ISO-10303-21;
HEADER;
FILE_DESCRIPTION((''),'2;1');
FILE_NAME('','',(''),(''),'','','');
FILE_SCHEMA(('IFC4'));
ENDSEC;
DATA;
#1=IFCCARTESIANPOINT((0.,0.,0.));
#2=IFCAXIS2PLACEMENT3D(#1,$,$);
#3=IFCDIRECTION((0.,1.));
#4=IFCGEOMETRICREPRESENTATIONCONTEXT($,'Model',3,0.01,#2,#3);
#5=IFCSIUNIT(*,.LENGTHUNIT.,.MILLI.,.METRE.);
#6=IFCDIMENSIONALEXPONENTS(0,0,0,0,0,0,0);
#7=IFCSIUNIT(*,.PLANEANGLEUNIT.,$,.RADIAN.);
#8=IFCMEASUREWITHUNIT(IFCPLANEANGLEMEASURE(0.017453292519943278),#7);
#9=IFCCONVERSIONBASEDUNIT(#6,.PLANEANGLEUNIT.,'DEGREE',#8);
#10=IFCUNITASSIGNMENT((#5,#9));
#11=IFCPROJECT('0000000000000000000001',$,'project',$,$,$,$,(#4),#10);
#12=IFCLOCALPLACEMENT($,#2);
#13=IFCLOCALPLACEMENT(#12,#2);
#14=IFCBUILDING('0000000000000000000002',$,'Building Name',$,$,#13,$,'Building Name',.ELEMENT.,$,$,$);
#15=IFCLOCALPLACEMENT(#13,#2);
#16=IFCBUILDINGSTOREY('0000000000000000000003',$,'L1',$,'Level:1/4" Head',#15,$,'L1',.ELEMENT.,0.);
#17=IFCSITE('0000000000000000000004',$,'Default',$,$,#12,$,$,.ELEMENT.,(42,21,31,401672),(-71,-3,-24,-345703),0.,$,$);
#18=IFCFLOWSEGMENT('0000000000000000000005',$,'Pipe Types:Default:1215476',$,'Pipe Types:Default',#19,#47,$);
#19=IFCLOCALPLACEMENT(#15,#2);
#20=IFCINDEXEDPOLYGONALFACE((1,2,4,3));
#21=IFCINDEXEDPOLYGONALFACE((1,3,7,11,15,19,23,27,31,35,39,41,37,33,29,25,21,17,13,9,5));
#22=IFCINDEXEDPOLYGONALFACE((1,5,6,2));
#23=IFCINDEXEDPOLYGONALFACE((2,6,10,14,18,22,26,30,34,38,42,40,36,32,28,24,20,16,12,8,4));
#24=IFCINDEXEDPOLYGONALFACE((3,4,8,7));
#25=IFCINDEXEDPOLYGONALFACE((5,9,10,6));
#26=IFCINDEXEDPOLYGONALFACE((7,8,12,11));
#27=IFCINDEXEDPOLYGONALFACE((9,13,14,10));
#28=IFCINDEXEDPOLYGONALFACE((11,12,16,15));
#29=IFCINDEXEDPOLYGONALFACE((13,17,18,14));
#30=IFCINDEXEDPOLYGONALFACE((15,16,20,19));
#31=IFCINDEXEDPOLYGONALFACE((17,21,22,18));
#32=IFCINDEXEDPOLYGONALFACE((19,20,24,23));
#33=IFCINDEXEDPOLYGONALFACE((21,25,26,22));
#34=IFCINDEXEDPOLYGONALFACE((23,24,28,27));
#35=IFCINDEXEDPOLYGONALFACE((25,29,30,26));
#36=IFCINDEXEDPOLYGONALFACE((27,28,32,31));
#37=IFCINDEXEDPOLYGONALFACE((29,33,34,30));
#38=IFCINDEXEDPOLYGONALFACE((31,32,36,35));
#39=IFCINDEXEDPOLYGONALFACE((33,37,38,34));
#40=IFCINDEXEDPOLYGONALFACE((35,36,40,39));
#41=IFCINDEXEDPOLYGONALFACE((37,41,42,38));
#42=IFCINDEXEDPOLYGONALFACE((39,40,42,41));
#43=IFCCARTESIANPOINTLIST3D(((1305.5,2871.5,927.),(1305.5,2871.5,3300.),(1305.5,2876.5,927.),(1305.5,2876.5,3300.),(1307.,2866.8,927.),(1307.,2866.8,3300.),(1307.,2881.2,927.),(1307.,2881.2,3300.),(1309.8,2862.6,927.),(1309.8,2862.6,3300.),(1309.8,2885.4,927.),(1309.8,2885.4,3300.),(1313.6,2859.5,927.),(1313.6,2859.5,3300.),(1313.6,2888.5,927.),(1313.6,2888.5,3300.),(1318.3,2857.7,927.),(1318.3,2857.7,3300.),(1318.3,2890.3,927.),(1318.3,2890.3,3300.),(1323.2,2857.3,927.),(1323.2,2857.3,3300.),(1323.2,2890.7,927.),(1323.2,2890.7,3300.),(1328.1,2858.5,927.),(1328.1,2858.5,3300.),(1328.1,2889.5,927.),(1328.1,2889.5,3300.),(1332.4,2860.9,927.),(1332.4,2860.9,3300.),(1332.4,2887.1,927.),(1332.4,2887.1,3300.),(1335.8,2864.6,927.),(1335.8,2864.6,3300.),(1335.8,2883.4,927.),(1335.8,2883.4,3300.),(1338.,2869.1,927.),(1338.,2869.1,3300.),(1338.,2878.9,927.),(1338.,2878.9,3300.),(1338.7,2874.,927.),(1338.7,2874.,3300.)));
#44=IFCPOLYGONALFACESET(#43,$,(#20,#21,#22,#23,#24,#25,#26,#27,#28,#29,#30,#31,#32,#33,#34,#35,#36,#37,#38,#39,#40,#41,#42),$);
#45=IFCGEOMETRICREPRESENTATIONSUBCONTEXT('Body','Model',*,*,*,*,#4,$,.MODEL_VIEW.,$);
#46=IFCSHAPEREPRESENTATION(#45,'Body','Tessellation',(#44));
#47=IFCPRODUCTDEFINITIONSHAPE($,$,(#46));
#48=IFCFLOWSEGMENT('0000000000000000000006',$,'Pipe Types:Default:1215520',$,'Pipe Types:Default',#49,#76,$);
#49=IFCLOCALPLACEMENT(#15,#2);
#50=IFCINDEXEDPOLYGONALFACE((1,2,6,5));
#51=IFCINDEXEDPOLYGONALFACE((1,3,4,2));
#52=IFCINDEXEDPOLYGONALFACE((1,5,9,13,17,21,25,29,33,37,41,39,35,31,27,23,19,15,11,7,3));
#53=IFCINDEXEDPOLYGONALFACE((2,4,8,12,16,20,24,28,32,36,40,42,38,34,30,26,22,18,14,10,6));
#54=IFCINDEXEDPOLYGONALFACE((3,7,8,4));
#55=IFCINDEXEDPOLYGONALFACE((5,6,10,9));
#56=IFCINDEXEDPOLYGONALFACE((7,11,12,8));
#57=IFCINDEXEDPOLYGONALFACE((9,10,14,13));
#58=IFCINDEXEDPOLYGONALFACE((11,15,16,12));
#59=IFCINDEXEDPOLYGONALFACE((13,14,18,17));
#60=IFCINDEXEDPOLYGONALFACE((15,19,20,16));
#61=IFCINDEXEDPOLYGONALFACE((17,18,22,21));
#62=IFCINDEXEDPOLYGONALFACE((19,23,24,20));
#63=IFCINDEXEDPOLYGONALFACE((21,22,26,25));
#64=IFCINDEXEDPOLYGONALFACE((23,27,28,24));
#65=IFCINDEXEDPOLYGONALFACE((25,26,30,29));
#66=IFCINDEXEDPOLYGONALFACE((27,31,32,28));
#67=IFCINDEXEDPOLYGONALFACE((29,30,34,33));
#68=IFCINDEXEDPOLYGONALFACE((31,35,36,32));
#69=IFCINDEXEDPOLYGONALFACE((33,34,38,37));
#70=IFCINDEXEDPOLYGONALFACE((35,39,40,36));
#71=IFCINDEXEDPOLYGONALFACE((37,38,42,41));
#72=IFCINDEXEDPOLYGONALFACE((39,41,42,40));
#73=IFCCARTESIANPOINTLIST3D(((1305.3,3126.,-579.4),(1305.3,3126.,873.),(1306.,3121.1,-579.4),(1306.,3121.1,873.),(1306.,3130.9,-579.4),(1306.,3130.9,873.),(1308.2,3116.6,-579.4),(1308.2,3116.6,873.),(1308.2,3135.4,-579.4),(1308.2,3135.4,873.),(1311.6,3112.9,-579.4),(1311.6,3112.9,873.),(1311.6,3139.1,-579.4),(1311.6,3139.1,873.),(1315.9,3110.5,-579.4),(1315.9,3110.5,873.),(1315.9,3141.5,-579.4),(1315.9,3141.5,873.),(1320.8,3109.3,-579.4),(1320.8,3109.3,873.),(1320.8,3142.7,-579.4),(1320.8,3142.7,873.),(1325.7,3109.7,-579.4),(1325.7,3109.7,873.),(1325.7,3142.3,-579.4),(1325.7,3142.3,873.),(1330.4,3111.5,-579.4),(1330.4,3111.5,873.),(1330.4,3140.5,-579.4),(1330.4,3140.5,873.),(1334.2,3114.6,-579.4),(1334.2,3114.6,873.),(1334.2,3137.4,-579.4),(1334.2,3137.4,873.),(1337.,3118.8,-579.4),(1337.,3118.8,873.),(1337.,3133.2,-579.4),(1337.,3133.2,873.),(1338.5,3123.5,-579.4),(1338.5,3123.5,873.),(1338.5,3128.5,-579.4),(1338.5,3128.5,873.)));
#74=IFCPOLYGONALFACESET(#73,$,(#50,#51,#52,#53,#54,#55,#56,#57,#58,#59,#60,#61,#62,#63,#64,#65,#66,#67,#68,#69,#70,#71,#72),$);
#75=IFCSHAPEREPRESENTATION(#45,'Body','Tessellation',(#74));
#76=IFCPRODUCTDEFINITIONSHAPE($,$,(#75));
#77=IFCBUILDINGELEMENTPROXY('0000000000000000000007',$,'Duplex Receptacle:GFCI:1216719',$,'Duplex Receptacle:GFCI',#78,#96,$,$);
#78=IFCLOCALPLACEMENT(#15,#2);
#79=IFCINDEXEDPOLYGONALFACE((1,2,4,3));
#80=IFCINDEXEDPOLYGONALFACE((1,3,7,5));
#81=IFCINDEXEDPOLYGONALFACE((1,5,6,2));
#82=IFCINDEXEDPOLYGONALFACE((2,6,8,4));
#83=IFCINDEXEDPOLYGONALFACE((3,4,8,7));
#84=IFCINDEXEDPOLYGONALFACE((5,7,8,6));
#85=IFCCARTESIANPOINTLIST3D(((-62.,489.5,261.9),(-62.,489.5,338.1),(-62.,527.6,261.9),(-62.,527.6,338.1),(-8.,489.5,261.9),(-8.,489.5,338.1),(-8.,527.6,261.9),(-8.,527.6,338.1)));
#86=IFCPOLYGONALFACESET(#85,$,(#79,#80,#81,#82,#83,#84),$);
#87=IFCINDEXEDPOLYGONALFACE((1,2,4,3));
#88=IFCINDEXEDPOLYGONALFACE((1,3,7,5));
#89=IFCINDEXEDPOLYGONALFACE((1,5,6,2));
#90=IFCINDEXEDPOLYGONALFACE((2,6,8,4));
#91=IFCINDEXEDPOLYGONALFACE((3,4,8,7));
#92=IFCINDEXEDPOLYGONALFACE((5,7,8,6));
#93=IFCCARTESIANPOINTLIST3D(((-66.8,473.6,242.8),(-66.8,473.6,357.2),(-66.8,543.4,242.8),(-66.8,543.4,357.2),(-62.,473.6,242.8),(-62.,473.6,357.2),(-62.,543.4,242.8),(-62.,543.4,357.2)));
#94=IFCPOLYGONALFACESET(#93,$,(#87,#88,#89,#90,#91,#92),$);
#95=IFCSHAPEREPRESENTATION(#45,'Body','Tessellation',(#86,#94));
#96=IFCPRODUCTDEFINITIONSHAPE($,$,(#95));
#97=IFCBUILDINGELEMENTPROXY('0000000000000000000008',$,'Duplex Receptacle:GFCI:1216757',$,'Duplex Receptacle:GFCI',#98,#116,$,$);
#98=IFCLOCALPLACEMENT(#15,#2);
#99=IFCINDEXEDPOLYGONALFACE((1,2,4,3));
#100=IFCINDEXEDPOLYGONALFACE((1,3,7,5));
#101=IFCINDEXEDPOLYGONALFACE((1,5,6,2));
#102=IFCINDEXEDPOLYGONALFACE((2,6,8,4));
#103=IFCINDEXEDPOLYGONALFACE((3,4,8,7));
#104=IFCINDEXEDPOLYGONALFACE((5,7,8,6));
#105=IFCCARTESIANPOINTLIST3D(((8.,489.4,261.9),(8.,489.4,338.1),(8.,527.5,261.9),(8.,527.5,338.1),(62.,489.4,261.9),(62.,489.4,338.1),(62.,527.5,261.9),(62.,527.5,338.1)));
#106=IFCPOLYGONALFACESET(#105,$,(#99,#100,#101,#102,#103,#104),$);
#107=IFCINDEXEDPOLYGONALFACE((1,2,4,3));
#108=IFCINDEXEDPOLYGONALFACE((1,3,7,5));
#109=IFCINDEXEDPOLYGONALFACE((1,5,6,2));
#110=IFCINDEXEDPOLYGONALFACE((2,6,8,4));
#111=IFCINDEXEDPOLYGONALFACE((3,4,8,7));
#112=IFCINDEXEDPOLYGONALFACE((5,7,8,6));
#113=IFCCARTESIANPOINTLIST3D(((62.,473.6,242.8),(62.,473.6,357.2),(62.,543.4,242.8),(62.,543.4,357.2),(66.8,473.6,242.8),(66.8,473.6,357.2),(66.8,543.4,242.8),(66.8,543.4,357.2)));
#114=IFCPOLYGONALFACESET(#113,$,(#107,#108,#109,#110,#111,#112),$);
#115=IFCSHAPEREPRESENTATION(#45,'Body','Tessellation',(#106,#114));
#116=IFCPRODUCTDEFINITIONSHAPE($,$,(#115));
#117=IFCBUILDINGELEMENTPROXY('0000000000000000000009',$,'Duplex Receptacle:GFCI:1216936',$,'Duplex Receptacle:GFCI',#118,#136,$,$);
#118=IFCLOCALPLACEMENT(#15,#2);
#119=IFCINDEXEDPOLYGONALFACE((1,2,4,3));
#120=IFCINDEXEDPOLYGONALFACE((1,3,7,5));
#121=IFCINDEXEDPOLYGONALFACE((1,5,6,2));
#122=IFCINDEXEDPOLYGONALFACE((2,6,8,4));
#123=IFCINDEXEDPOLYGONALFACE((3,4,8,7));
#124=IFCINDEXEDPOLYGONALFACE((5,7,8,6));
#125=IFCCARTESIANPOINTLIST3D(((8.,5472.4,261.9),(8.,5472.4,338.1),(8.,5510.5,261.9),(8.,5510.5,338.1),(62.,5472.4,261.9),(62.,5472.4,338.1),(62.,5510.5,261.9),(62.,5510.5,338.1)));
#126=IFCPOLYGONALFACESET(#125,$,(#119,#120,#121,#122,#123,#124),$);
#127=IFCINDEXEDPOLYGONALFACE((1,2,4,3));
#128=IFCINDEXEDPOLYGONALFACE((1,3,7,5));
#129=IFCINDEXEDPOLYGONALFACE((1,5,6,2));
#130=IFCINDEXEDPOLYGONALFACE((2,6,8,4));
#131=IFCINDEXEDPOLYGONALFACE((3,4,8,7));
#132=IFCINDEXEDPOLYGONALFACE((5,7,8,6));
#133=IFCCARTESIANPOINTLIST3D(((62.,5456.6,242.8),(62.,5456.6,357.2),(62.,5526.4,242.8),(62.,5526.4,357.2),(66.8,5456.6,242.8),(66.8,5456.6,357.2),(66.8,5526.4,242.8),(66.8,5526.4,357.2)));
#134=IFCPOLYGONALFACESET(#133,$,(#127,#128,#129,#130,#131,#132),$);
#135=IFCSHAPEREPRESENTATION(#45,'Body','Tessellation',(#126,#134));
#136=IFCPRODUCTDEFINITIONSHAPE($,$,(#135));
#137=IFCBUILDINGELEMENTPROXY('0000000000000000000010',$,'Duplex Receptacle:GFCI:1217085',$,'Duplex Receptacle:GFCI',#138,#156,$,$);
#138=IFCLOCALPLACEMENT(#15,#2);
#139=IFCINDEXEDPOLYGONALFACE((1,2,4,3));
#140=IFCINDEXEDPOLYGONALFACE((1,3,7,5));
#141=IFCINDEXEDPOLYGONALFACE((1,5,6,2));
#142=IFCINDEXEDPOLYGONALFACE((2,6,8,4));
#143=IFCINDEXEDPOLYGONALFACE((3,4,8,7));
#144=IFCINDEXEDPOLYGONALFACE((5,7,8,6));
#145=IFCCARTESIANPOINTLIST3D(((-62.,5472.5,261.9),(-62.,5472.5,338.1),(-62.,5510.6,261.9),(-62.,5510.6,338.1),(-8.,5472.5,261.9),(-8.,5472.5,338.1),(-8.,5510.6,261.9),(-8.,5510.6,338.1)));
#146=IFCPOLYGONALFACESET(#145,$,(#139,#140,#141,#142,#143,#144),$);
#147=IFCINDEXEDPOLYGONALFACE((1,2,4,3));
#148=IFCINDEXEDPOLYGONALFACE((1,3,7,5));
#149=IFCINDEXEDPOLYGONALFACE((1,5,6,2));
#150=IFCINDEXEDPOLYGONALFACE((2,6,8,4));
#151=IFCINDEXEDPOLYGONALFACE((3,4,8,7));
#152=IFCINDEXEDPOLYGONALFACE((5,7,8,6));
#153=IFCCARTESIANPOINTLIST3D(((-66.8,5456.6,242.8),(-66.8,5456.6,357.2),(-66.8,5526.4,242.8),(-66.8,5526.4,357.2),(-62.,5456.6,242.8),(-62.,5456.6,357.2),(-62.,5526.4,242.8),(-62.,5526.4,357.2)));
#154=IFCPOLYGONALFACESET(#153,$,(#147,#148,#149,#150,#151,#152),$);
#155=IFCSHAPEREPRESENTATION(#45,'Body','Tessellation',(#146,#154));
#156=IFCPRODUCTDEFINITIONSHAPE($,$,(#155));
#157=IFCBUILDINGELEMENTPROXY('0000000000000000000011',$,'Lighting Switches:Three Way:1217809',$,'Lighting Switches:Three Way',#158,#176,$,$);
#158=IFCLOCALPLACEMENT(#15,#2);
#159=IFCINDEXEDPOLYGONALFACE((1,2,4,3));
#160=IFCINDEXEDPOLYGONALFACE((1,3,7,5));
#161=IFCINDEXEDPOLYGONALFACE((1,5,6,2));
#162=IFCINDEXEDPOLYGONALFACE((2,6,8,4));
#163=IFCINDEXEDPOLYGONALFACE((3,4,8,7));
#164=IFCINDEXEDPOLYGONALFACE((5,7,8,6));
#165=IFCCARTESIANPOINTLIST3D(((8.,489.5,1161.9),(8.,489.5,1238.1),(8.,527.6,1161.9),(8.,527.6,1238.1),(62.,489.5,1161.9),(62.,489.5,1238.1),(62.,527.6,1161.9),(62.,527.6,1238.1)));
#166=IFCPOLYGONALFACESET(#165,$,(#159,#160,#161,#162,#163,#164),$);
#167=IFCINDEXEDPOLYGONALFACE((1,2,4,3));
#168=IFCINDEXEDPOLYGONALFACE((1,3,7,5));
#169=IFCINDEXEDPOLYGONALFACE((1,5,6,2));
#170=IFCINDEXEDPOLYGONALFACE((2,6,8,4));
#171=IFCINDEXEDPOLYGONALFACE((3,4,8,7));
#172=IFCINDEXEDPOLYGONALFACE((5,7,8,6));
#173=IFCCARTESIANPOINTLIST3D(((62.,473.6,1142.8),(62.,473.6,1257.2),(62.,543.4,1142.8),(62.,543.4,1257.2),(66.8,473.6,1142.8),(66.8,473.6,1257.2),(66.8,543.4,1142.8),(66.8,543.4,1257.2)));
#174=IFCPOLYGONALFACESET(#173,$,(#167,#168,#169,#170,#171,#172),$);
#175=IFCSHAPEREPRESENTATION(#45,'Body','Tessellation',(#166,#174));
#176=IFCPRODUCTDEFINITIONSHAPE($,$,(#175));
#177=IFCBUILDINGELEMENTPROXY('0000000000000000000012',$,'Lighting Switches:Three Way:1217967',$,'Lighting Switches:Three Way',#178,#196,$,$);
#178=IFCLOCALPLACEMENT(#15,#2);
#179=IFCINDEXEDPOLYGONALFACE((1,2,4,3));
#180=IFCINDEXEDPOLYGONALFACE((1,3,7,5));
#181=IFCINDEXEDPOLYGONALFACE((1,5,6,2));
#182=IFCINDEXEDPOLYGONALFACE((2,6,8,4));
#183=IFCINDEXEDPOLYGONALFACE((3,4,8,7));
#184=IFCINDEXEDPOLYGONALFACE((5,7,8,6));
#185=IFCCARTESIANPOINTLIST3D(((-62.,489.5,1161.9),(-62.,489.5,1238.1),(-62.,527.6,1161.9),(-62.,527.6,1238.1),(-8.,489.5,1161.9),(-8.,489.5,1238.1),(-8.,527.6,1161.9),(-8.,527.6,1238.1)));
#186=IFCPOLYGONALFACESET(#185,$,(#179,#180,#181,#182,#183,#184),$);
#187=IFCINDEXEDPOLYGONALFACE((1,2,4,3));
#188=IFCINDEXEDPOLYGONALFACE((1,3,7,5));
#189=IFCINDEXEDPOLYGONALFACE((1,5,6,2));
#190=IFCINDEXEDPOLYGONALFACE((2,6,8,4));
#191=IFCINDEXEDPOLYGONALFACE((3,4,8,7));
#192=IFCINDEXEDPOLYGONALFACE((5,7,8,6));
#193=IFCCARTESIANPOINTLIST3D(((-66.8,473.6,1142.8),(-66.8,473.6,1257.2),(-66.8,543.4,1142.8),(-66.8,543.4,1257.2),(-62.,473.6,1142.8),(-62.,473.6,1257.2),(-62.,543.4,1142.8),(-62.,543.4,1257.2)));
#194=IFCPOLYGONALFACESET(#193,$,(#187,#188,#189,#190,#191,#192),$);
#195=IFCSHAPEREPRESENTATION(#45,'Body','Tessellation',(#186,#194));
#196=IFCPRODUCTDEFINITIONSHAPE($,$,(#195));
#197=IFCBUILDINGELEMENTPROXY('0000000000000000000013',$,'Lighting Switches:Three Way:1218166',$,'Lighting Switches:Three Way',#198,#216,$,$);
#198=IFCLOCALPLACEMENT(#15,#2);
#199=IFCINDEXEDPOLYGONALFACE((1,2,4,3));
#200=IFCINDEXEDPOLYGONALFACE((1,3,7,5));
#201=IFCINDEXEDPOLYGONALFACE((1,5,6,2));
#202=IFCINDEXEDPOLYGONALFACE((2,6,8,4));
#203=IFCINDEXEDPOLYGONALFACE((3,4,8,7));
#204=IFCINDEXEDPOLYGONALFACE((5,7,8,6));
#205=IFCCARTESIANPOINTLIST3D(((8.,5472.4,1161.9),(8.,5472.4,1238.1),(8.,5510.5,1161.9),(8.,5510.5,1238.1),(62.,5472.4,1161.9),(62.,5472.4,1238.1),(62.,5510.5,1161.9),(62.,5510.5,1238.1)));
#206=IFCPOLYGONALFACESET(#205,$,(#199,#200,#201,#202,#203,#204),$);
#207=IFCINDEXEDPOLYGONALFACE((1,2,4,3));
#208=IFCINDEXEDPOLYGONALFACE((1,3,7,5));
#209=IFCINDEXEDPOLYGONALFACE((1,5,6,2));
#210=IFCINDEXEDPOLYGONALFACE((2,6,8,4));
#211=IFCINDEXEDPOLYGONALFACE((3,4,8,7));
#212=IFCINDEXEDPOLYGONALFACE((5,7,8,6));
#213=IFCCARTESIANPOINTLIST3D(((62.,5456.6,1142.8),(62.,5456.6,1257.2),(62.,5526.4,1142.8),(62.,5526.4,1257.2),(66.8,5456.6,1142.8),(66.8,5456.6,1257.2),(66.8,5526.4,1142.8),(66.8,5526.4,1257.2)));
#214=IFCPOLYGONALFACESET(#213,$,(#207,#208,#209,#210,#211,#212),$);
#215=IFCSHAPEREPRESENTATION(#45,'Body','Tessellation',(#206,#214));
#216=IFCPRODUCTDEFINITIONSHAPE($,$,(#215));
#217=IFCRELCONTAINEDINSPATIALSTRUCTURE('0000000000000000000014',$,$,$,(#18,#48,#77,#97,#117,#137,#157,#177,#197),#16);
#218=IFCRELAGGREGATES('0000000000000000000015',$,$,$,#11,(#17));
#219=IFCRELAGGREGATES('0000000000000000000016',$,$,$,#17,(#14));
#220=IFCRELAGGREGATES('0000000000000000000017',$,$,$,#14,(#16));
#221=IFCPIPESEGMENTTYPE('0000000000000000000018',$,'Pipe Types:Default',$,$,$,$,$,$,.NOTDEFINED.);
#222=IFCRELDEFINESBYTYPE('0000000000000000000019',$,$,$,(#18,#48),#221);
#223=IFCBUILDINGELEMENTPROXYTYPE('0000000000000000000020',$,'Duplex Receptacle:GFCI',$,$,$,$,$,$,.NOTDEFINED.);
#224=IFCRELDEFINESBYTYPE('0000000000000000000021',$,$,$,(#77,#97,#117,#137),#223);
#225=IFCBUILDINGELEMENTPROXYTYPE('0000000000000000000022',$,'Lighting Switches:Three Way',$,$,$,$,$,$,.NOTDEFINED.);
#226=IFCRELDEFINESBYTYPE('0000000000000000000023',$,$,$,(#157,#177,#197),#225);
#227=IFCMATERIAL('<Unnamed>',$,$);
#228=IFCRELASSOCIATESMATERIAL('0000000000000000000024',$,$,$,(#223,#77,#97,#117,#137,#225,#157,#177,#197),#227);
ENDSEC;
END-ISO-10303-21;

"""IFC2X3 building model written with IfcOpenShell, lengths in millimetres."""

from ifc_helpers import new_model, entity, si_unit, converted_unit, direction, frame, frame_2d, origin, origin_2d_with_axis, place, context, subcontext, project, spatial, rectangle, circle, extrude, source, transform, mapped, material, type_object, type_shapes, element, save


model = new_model("IFC2X3")

# Units and contexts
model_context = context("Model", 3, precision=0.01, world=origin(), true_north=direction((0.0, 1.0)))
body_context = subcontext(model_context, "Body", "Model", "MODEL_VIEW")
ifc_project = project(units=[si_unit("LENGTHUNIT", "METRE", prefix="MILLI"), converted_unit("PLANEANGLEUNIT", "DEGREE", entity("IfcPlaneAngleMeasure", 0.017453292519943278), si_unit("PLANEANGLEUNIT", "RADIAN"), dimensions=[0, 0, 0, 0, 0, 0, 0])], contexts=[model_context])

# Site, building, storey
site_placement = place(None, origin())
site = spatial("IfcSite", under=ifc_project, at=site_placement, Name="Default", CompositionType="ELEMENT", RefLatitude=(42, 21, 31, 401672), RefLongitude=(-71, -3, -24, -345703), RefElevation=0.0)
building_placement = place(site_placement, origin())
building = spatial("IfcBuilding", under=site, at=building_placement, Name="Building Name", LongName="Building Name", CompositionType="ELEMENT")
storey_placement = place(building_placement, origin())
storey = spatial("IfcBuildingStorey", under=building, at=storey_placement, Name="L1", ObjectType="Level:1/4\" Head", LongName="L1", CompositionType="ELEMENT", Elevation=0.0)

# Flow segments
pipe_segment_type = type_object("IfcPipeSegmentType", Name="Pipe Types:Default", PredefinedType="NOTDEFINED")
flow_segment_1_placement = place(storey_placement, origin())
element("IfcFlowSegment", 1, at=flow_segment_1_placement, inside=storey, type_object=pipe_segment_type, Name="Pipe Types:Default:1215476", ObjectType="Pipe Types:Default", context=body_context, shape_type="SweptSolid", body=[
    extrude(circle(Radius=16.7, at=origin_2d_with_axis()), frame((1322.0, 2874.0, 927.0)), (0.0, 0.0, 1.0), 2373.0),
])
flow_segment_2_placement = place(storey_placement, origin())
element("IfcFlowSegment", 2, at=flow_segment_2_placement, inside=storey, type_object=pipe_segment_type, Name="Pipe Types:Default:1215520", ObjectType="Pipe Types:Default", context=body_context, shape_type="SweptSolid", body=[
    extrude(circle(Radius=16.7, at=origin_2d_with_axis()), frame((1322.0, 3126.0, -579.4), z_axis=(0.0, 0.0, 1.0), x_axis=(-1.0, 0.0, 0.0)), (0.0, 0.0, 1.0), 1452.4),
])

# Building element proxies
ifc_material = material(Name="<Unnamed>")
building_element_proxy_type_1 = type_object("IfcBuildingElementProxyType", Name="Duplex Receptacle:GFCI", PredefinedType="NOTDEFINED", material=ifc_material)
shared_shape_1 = source(origin(), body_context, "Body", "SweptSolid", [
    extrude(rectangle(XDim=38.1, YDim=76.2, at=origin_2d_with_axis()), frame((0.0, 0.0, -54.0), z_axis=(0.0, 0.0, 1.0), x_axis=(-1.0, 0.0, 0.0)), (0.0, 0.0, 1.0), 54.0),
    extrude(rectangle(XDim=69.8, YDim=114.3, at=frame_2d((0.0, 0.0), x_axis=(1.0, 0.0))), frame((0.0, 0.0, 0.0), z_axis=(0.0, 0.0, 1.0), x_axis=(-1.0, 0.0, 0.0)), (0.0, 0.0, 1.0), 4.8),
])
type_shapes(building_element_proxy_type_1, [shared_shape_1])
for number, where, z_axis, x_axis, name in (
    (3, (-62.0, 508.5, 300.0), (-1.0, 0.0, 0.0), (0.0, -1.0, 0.0), "Duplex Receptacle:GFCI:1216719"),
    (4, (62.0, 508.5, 300.0), (1.0, 0.0, 0.0), (0.0, 1.0, 0.0), "Duplex Receptacle:GFCI:1216757"),
    (5, (62.0, 5491.5, 300.0), (1.0, 0.0, 0.0), (0.0, 1.0, 0.0), "Duplex Receptacle:GFCI:1216936"),
    (6, (-62.0, 5491.5, 300.0), (-1.0, 0.0, 0.0), (0.0, -1.0, 0.0), "Duplex Receptacle:GFCI:1217085"),
):
    element("IfcBuildingElementProxy", number, at=place(storey_placement, frame(where, z_axis=z_axis, x_axis=x_axis)), inside=storey, type_object=building_element_proxy_type_1, material=ifc_material, Name=name, ObjectType="Duplex Receptacle:GFCI", context=body_context, shape_type="MappedRepresentation", body=[
        mapped(shared_shape_1, transform((0.0, 0.0, 0.0), scale=1.0)),
    ])
building_element_proxy_type_2 = type_object("IfcBuildingElementProxyType", Name="Lighting Switches:Three Way", PredefinedType="NOTDEFINED", material=ifc_material)
shared_shape_2 = source(origin(), body_context, "Body", "SweptSolid", [
    extrude(rectangle(XDim=38.1, YDim=76.2, at=origin_2d_with_axis()), frame((0.0, 0.0, -54.0), z_axis=(0.0, 0.0, 1.0), x_axis=(-1.0, 0.0, 0.0)), (0.0, 0.0, 1.0), 54.0),
    extrude(rectangle(XDim=69.8, YDim=114.3, at=frame_2d((0.0, 0.0), x_axis=(1.0, 0.0))), frame((0.0, 0.0, 0.0), z_axis=(0.0, 0.0, 1.0), x_axis=(-1.0, 0.0, 0.0)), (0.0, 0.0, 1.0), 4.8),
])
type_shapes(building_element_proxy_type_2, [shared_shape_2])
for number, where, z_axis, x_axis, name in (
    (7, (62.0, 508.5, 1200.0), (1.0, 0.0, 0.0), (0.0, -1.0, 0.0), "Lighting Switches:Three Way:1217809"),
    (8, (-62.0, 508.5, 1200.0), (-1.0, 0.0, 0.0), (0.0, -1.0, 0.0), "Lighting Switches:Three Way:1217967"),
    (9, (62.0, 5491.5, 1200.0), (1.0, 0.0, 0.0), (0.0, 1.0, 0.0), "Lighting Switches:Three Way:1218166"),
):
    element("IfcBuildingElementProxy", number, at=place(storey_placement, frame(where, z_axis=z_axis, x_axis=x_axis)), inside=storey, type_object=building_element_proxy_type_2, material=ifc_material, Name=name, ObjectType="Lighting Switches:Three Way", context=body_context, shape_type="MappedRepresentation", body=[
        mapped(shared_shape_2, transform((0.0, 0.0, 0.0), scale=1.0)),
    ])

save(model, "model.ifc")
